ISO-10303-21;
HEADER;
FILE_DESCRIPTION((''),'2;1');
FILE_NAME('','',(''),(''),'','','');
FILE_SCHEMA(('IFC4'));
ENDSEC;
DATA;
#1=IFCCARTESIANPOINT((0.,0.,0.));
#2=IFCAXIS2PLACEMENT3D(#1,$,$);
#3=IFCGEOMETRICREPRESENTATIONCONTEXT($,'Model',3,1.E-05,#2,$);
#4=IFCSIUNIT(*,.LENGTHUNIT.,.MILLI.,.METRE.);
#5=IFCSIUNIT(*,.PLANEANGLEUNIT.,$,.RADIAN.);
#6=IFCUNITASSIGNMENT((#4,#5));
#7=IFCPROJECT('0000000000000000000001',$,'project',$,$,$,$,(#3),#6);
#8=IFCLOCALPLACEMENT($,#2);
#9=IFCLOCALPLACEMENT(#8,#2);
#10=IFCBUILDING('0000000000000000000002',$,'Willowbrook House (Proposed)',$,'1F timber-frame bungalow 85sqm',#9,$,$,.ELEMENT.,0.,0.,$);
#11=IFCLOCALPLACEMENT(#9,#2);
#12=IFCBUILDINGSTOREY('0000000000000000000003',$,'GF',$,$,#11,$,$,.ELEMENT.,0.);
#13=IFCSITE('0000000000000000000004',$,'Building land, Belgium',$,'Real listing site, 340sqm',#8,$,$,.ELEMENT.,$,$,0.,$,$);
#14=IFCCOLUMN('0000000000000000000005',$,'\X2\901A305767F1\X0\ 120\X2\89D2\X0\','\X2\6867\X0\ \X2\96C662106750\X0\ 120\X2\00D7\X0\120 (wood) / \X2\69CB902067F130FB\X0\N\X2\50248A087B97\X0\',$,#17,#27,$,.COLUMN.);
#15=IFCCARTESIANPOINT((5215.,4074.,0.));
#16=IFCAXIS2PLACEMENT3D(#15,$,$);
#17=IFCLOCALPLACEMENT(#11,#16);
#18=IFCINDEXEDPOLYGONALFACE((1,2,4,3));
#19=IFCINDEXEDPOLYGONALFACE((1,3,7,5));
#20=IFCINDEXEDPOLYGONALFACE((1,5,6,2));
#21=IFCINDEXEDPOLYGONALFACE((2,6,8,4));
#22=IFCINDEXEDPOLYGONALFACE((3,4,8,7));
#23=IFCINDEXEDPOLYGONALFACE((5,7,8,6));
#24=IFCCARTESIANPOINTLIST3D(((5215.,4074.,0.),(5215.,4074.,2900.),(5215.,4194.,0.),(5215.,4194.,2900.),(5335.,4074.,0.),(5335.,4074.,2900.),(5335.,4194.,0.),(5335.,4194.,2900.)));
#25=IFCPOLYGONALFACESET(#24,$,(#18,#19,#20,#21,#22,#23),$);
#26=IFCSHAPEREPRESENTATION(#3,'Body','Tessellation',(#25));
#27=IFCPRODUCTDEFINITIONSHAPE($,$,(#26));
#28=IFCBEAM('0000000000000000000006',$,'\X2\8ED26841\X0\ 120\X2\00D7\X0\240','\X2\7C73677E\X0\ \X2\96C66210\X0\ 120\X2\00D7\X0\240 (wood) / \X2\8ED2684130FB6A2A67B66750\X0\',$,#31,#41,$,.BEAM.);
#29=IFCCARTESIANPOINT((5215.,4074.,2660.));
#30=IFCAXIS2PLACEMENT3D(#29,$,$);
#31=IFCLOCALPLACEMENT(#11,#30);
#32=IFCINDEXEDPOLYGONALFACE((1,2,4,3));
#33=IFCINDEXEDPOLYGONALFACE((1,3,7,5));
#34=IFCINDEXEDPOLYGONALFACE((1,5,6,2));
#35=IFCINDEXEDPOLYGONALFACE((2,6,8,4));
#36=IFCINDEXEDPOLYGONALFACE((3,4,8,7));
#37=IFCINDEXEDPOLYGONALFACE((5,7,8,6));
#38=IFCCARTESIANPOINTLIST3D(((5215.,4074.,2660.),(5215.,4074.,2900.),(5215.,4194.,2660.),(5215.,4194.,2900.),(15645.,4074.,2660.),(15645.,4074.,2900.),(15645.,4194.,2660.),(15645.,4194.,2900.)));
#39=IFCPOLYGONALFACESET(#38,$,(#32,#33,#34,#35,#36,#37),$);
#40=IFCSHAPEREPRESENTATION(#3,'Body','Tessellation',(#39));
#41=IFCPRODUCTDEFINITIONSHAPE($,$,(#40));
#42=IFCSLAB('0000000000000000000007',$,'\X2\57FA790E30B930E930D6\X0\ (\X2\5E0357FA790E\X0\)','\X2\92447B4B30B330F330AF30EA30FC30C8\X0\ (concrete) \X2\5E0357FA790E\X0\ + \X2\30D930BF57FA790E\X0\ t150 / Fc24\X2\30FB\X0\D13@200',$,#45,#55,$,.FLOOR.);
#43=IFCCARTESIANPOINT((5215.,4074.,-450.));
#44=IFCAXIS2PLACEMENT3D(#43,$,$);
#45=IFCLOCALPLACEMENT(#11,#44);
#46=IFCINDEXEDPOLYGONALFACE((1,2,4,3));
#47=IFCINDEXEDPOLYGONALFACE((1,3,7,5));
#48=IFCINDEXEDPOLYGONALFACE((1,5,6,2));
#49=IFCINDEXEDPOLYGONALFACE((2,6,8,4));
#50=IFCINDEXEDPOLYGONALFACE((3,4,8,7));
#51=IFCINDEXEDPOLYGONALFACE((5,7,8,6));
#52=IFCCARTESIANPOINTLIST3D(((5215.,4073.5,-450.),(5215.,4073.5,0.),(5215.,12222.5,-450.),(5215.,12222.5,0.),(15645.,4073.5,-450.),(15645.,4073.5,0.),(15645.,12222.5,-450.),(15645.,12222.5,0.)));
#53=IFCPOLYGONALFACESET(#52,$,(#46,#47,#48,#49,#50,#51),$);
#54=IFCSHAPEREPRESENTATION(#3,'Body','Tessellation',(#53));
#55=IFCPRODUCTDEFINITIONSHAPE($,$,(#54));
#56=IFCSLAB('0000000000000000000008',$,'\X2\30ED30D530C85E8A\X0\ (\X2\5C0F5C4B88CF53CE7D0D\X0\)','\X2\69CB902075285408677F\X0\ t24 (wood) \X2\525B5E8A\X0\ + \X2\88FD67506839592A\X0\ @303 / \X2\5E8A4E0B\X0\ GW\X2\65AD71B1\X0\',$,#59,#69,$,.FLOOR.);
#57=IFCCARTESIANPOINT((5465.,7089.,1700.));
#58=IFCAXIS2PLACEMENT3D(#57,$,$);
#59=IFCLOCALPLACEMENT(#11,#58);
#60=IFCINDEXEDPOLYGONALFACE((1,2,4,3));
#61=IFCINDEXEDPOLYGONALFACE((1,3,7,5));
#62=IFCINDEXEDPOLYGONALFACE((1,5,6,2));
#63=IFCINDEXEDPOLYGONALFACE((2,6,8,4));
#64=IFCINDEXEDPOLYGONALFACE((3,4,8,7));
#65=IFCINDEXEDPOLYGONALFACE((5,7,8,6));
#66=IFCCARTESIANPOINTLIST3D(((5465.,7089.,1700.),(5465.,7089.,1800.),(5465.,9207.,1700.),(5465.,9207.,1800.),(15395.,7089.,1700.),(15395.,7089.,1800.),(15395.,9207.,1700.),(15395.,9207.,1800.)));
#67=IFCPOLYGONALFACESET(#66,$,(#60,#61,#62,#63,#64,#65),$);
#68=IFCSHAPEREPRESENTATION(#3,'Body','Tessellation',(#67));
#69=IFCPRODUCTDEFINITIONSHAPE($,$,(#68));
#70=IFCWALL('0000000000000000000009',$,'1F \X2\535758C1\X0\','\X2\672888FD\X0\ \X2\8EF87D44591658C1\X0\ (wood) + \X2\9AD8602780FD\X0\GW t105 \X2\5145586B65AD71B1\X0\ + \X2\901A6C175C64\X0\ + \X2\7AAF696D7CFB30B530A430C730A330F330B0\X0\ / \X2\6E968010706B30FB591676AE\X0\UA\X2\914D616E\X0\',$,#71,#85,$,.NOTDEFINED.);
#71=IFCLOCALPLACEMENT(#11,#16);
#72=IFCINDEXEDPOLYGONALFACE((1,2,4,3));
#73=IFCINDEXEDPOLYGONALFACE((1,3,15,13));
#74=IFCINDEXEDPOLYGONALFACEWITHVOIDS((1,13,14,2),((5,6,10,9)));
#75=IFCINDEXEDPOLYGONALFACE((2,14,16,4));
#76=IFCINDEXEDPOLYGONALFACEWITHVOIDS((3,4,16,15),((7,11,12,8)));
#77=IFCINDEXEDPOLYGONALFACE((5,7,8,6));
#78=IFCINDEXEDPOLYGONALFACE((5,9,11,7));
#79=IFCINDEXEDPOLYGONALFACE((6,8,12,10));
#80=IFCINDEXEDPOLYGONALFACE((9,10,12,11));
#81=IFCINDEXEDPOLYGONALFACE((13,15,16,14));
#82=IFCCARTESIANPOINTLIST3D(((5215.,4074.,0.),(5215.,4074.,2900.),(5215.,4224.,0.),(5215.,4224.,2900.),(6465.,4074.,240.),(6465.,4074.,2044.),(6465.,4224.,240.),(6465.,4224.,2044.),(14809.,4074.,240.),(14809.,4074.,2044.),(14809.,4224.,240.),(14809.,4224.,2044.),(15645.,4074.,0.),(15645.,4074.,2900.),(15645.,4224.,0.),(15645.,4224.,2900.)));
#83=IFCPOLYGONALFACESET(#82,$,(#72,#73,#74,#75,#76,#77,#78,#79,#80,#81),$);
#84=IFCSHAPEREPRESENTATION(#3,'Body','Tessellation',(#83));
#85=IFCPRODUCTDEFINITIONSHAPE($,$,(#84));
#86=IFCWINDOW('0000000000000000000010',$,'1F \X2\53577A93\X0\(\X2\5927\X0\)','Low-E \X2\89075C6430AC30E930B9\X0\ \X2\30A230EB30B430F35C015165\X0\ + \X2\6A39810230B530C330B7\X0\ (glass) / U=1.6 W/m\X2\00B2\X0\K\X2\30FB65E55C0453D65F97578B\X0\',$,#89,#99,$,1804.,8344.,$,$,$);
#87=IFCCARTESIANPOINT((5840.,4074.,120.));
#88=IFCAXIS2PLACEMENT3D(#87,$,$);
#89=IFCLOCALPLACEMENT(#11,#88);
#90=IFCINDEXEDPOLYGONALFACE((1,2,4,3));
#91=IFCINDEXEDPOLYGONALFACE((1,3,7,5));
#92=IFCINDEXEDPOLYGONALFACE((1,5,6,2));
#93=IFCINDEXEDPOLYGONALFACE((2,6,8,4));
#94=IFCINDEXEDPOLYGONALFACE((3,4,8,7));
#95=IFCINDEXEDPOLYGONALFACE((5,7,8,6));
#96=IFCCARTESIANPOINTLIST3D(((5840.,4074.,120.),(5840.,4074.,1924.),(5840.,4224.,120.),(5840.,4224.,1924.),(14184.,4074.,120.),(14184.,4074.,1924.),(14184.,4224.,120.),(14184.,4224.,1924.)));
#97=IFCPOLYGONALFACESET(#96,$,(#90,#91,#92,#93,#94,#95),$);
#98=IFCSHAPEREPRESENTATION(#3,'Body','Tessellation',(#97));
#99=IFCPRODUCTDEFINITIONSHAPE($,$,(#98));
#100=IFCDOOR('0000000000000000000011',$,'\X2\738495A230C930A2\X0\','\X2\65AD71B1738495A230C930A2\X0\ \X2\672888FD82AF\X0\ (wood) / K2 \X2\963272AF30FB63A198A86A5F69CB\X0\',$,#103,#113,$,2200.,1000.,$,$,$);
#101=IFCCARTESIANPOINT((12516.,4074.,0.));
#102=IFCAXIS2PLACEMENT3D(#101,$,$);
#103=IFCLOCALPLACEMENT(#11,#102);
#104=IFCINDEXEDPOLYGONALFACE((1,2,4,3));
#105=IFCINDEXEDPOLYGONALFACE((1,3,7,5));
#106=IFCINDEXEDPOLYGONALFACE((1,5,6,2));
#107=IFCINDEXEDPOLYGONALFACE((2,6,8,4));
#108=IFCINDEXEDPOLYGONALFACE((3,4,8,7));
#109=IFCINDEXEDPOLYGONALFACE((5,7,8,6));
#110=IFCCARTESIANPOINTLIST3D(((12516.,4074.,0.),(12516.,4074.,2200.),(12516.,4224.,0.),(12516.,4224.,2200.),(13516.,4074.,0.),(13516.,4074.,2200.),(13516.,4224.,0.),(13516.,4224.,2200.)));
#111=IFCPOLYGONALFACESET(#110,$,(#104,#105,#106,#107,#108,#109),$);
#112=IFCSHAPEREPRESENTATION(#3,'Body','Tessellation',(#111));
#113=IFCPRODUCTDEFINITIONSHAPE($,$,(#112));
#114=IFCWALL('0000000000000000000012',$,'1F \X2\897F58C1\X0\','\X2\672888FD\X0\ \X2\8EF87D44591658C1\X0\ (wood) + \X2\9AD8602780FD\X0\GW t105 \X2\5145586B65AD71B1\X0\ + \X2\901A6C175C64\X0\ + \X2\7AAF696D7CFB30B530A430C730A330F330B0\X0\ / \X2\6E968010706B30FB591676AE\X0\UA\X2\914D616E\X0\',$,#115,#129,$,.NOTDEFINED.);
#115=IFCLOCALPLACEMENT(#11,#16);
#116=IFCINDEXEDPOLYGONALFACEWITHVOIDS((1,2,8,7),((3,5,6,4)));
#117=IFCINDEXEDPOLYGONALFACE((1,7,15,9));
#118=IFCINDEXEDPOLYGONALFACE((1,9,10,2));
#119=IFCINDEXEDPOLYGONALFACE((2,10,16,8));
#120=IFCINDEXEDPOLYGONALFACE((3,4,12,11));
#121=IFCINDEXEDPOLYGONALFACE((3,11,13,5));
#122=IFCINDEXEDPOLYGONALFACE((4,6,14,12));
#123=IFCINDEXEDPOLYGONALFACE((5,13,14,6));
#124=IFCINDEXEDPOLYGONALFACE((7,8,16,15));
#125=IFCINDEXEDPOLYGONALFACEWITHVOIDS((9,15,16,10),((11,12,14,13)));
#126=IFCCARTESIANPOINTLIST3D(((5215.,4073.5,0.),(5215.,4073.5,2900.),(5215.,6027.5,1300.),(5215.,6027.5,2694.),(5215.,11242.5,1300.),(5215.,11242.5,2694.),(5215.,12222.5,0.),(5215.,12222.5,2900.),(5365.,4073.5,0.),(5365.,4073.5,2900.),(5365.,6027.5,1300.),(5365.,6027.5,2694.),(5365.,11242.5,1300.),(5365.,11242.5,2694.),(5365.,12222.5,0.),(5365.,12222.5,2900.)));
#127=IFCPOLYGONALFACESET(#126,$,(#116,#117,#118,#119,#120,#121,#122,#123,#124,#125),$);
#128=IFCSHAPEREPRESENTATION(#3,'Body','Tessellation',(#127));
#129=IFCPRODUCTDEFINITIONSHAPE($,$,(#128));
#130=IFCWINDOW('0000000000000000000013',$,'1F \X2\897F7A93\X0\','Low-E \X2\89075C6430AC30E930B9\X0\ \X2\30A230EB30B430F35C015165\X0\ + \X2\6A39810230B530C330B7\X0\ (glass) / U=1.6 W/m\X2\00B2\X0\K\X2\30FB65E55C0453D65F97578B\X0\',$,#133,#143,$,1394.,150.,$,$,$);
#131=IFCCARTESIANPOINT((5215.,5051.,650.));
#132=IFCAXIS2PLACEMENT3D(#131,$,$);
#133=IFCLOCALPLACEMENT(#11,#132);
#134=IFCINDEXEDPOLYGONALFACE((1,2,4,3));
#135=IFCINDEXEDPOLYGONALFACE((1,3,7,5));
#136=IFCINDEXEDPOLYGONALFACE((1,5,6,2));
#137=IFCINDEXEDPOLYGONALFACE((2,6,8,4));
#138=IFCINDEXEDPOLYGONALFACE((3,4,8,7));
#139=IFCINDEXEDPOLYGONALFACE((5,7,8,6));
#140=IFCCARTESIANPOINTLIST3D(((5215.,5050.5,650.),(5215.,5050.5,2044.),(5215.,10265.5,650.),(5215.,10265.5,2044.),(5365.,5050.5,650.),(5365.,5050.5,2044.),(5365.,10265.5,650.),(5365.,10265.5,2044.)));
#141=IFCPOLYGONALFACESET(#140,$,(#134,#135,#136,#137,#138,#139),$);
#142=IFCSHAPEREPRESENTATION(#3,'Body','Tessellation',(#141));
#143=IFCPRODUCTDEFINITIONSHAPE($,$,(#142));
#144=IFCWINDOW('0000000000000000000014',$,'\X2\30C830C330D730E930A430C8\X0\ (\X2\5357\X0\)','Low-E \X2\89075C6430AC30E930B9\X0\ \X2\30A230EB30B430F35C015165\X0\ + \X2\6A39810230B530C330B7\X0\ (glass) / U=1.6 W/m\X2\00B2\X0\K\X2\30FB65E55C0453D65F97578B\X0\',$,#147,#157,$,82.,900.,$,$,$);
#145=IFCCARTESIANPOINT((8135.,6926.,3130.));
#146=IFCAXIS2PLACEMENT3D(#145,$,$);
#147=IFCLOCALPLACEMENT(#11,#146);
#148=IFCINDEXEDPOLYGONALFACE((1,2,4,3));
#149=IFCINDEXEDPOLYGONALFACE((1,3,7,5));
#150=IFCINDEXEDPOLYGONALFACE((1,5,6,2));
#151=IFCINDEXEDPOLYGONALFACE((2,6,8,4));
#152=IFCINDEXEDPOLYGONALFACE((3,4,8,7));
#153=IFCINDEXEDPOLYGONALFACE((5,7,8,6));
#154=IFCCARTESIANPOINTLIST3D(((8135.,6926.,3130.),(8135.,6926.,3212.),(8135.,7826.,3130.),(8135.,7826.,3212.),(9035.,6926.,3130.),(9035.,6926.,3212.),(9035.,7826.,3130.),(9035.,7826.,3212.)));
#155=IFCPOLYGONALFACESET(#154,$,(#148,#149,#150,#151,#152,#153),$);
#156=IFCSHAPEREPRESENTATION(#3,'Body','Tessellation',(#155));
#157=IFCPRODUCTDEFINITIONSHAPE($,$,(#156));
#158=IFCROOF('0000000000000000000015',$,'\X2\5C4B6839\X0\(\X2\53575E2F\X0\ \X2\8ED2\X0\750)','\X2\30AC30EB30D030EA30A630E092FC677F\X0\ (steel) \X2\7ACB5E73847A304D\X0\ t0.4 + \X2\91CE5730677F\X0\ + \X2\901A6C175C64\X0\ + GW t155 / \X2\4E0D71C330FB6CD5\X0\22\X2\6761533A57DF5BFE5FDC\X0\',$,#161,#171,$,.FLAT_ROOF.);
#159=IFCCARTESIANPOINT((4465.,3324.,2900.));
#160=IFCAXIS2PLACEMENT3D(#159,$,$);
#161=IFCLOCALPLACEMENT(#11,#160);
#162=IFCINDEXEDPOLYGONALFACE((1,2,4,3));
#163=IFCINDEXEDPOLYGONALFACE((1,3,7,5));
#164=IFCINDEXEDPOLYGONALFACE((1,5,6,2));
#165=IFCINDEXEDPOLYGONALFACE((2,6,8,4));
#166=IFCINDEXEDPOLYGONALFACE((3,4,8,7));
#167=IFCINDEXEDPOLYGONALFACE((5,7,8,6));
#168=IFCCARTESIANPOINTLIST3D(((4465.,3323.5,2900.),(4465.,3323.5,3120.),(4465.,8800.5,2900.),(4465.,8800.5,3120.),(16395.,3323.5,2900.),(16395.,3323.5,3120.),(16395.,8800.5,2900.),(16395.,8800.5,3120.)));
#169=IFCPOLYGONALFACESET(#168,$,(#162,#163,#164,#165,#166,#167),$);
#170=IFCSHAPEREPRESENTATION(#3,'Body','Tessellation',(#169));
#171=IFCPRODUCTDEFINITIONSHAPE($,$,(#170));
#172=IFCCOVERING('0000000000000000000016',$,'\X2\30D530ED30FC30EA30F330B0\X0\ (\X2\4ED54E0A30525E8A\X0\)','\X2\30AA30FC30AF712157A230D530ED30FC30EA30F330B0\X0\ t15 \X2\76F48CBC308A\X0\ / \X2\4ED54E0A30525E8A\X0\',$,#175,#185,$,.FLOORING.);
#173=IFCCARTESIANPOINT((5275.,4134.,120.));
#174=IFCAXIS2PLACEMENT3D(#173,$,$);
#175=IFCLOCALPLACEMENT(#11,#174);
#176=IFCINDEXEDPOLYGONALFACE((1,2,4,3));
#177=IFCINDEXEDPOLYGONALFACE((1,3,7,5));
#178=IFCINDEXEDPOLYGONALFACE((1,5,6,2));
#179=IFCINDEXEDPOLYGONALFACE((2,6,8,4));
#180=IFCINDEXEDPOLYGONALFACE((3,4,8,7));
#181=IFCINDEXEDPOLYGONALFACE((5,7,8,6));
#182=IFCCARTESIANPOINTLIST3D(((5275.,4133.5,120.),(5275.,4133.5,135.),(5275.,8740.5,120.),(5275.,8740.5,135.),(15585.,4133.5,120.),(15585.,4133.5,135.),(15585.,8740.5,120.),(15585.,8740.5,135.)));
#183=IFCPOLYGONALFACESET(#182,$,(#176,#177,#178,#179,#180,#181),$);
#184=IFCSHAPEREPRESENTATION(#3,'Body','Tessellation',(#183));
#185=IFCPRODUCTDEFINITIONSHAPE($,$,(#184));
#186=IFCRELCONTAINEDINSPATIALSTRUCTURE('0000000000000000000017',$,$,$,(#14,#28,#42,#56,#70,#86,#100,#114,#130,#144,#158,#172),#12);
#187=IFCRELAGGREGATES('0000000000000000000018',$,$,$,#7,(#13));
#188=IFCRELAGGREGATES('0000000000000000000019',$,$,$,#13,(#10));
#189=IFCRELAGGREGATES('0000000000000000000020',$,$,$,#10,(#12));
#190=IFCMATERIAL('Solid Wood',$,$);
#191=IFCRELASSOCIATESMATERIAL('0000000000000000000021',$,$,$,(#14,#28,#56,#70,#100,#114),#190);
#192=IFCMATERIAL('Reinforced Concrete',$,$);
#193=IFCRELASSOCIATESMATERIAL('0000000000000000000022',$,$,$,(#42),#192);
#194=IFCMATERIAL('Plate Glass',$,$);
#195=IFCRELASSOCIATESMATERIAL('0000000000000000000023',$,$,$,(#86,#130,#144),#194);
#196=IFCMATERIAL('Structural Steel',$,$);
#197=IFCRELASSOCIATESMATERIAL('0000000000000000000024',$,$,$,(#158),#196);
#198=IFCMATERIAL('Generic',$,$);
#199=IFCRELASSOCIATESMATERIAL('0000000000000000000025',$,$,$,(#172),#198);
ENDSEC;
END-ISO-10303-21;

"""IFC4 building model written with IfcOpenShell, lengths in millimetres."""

from ifc_helpers import new_model, si_unit, frame, frame_2d, origin, place, context, project, spatial, rectangle, extrude, material, element, fill, save


model = new_model("IFC4")

# Units and contexts
model_context = context("Model", 3, precision=1e-05, world=origin())
ifc_project = project(units=[si_unit("LENGTHUNIT", "METRE", prefix="MILLI"), si_unit("PLANEANGLEUNIT", "RADIAN")], contexts=[model_context])

# Site, building, storey
site_placement = place(None, origin())
site = spatial("IfcSite", under=ifc_project, at=site_placement, Name="Building land, Belgium", ObjectType="Real listing site, 340sqm", CompositionType="ELEMENT", RefElevation=0.0)
building_placement = place(site_placement, origin())
building = spatial("IfcBuilding", under=site, at=building_placement, Name="Willowbrook House (Proposed)", ObjectType="1F timber-frame bungalow 85sqm", CompositionType="ELEMENT", ElevationOfRefHeight=0.0, ElevationOfTerrain=0.0)
storey_placement = place(building_placement, origin())
storey = spatial("IfcBuildingStorey", under=building, at=storey_placement, Name="GF", CompositionType="ELEMENT", Elevation=0.0)

# Column
ifc_material_1 = material(Name="Solid Wood")
column_1_placement = place(storey_placement, frame((5215.0, 4074.0, 0.0)))
element("IfcColumn", 1, at=column_1_placement, inside=storey, material=ifc_material_1, Name="通し柱 120角", Description="桧 集成材 120×120 (wood) / 構造柱・N値計算", PredefinedType="COLUMN", context=model_context, shape_type="SweptSolid", body=[
    extrude(rectangle(XDim=120.0, YDim=120.0, at=frame_2d((60.0, 60.0))), frame((5215.0, 4074.0, 0.0)), (0.0, 0.0, 1.0), 2900.0),
])

# Beam
beam_1_placement = place(storey_placement, frame((5215.0, 4074.0, 2660.0)))
element("IfcBeam", 2, at=beam_1_placement, inside=storey, material=ifc_material_1, Name="軒桁 120×240", Description="米松 集成 120×240 (wood) / 軒桁・横架材", PredefinedType="BEAM", context=model_context, shape_type="SweptSolid", body=[
    extrude(rectangle(XDim=10430.0, YDim=120.0, at=frame_2d((5215.0, 60.0))), frame((5215.0, 4074.0, 2660.0)), (0.0, 0.0, 1.0), 240.0),
])

# Slabs
ifc_material_2 = material(Name="Reinforced Concrete")
slab_1_placement = place(storey_placement, frame((5215.0, 4074.0, -450.0)))
element("IfcSlab", 3, at=slab_1_placement, inside=storey, material=ifc_material_2, Name="基礎スラブ (布基礎)", Description="鉄筋コンクリート (concrete) 布基礎 + ベタ基礎 t150 / Fc24・D13@200", PredefinedType="FLOOR", context=model_context, shape_type="SweptSolid", body=[
    extrude(rectangle(XDim=10430.0, YDim=8149.0, at=frame_2d((5215.0, 4074.0))), frame((5215.0, 4074.0, -450.0)), (0.0, 0.0, 1.0), 450.0),
])
slab_2_placement = place(storey_placement, frame((5465.0, 7089.0, 1700.0)))
element("IfcSlab", 4, at=slab_2_placement, inside=storey, material=ifc_material_1, Name="ロフト床 (小屋裏収納)", Description="構造用合板 t24 (wood) 剛床 + 製材根太 @303 / 床下 GW断熱", PredefinedType="FLOOR", context=model_context, shape_type="SweptSolid", body=[
    extrude(rectangle(XDim=9930.0, YDim=2118.0, at=frame_2d((4965.0, 1059.0))), frame((5465.0, 7089.0, 1700.0)), (0.0, 0.0, 1.0), 100.0),
])

# Wall, openings, window, door
wall_1_placement = place(storey_placement, frame((5215.0, 4074.0, 0.0)))
wall_1 = element("IfcWall", 5, at=wall_1_placement, inside=storey, material=ifc_material_1, Name="1F 南壁", Description="木製 軸組外壁 (wood) + 高性能GW t105 充填断熱 + 通気層 + 窯業系サイディング / 準耐火・外皮UA配慮", PredefinedType="NOTDEFINED", context=model_context, shape_type="SweptSolid", body=[
    extrude(rectangle(XDim=10430.0, YDim=150.0, at=frame_2d((5215.0, 75.0))), frame((5215.0, 4074.0, 0.0)), (0.0, 0.0, 1.0), 2900.0),
])
opening_1_placement = place(storey_placement, frame((5840.0, 4074.0, 120.0)))
opening_1 = element("IfcOpeningElement", 6, at=opening_1_placement, cuts=wall_1, PredefinedType="NOTDEFINED", context=model_context, shape_type="SweptSolid", body=[
    extrude(rectangle(XDim=8344.0, YDim=150.0, at=frame_2d((4172.0, 75.0))), frame((5840.0, 4074.0, 120.0)), (0.0, 0.0, 1.0), 1804.0),
])
opening_2_placement = place(storey_placement, frame((12516.0, 4074.0, 0.0)))
opening_2 = element("IfcOpeningElement", 7, at=opening_2_placement, cuts=wall_1, PredefinedType="NOTDEFINED", context=model_context, shape_type="SweptSolid", body=[
    extrude(rectangle(XDim=1000.0, YDim=150.0, at=frame_2d((500.0, 75.0))), frame((12516.0, 4074.0, 0.0)), (0.0, 0.0, 1.0), 2200.0),
])
ifc_material_3 = material(Name="Plate Glass")
window_1_placement = place(storey_placement, frame((5840.0, 4074.0, 120.0)))
window_1 = element("IfcWindow", 8, at=window_1_placement, inside=storey, material=ifc_material_3, Name="1F 南窓(大)", Description="Low-E 複層ガラス アルゴン封入 + 樹脂サッシ (glass) / U=1.6 W/m²K・日射取得型", OverallHeight=1804.0, OverallWidth=8344.0, context=model_context, shape_type="SweptSolid", body=[
    extrude(rectangle(XDim=8344.0, YDim=150.0, at=frame_2d((4172.0, 75.0))), frame((5840.0, 4074.0, 120.0)), (0.0, 0.0, 1.0), 1804.0),
])
fill(opening_1, window_1)
door_placement = place(storey_placement, frame((12516.0, 4074.0, 0.0)))
door = element("IfcDoor", 9, at=door_placement, inside=storey, material=ifc_material_1, Name="玄関ドア", Description="断熱玄関ドア 木製芯 (wood) / K2 防犯・採風機構", OverallHeight=2200.0, OverallWidth=1000.0, context=model_context, shape_type="SweptSolid", body=[
    extrude(rectangle(XDim=1000.0, YDim=150.0, at=frame_2d((500.0, 75.0))), frame((12516.0, 4074.0, 0.0)), (0.0, 0.0, 1.0), 2200.0),
])
fill(opening_2, door)

# Wall, opening, window
wall_2_placement = place(storey_placement, frame((5215.0, 4074.0, 0.0)))
wall_2 = element("IfcWall", 10, at=wall_2_placement, inside=storey, material=ifc_material_1, Name="1F 西壁", Description="木製 軸組外壁 (wood) + 高性能GW t105 充填断熱 + 通気層 + 窯業系サイディング / 準耐火・外皮UA配慮", PredefinedType="NOTDEFINED", context=model_context, shape_type="SweptSolid", body=[
    extrude(rectangle(XDim=150.0, YDim=8149.0, at=frame_2d((75.0, 4074.0))), frame((5215.0, 4074.0, 0.0)), (0.0, 0.0, 1.0), 2900.0),
])
opening_3_placement = place(storey_placement, frame((5215.0, 5051.0, 650.0)))
opening_3 = element("IfcOpeningElement", 11, at=opening_3_placement, cuts=wall_2, PredefinedType="NOTDEFINED", context=model_context, shape_type="SweptSolid", body=[
    extrude(rectangle(XDim=150.0, YDim=5215.0, at=frame_2d((75.0, 2607.0))), frame((5215.0, 5051.0, 650.0)), (0.0, 0.0, 1.0), 1394.0),
])
window_2_placement = place(storey_placement, frame((5215.0, 5051.0, 650.0)))
window_2 = element("IfcWindow", 12, at=window_2_placement, inside=storey, material=ifc_material_3, Name="1F 西窓", Description="Low-E 複層ガラス アルゴン封入 + 樹脂サッシ (glass) / U=1.6 W/m²K・日射取得型", OverallHeight=1394.0, OverallWidth=150.0, context=model_context, shape_type="SweptSolid", body=[
    extrude(rectangle(XDim=150.0, YDim=5215.0, at=frame_2d((75.0, 2607.0))), frame((5215.0, 5051.0, 650.0)), (0.0, 0.0, 1.0), 1394.0),
])
fill(opening_3, window_2)

# Window
window_3_placement = place(storey_placement, frame((8135.0, 6926.0, 3130.0)))
element("IfcWindow", 13, at=window_3_placement, inside=storey, material=ifc_material_3, Name="トップライト (南)", Description="Low-E 複層ガラス アルゴン封入 + 樹脂サッシ (glass) / U=1.6 W/m²K・日射取得型", OverallHeight=82.0, OverallWidth=900.0, context=model_context, shape_type="SweptSolid", body=[
    extrude(rectangle(XDim=900.0, YDim=900.0, at=frame_2d((450.0, 450.0))), frame((8135.0, 6926.0, 3130.0)), (0.0, 0.0, 1.0), 82.0),
])

# Roof
ifc_material_4 = material(Name="Structural Steel")
roof_placement = place(storey_placement, frame((4465.0, 3324.0, 2900.0)))
element("IfcRoof", 14, at=roof_placement, inside=storey, material=ifc_material_4, Name="屋根(南帯 軒750)", Description="ガルバリウム鋼板 (steel) 立平葺き t0.4 + 野地板 + 通気層 + GW t155 / 不燃・法22条区域対応", PredefinedType="FLAT_ROOF", context=model_context, shape_type="SweptSolid", body=[
    extrude(rectangle(XDim=11930.0, YDim=5477.0, at=frame_2d((5965.0, 2738.0))), frame((4465.0, 3324.0, 2900.0)), (0.0, 0.0, 1.0), 220.0),
])

# Covering
ifc_material_5 = material(Name="Generic")
covering_1_placement = place(storey_placement, frame((5275.0, 4134.0, 120.0)))
element("IfcCovering", 15, at=covering_1_placement, inside=storey, material=ifc_material_5, Name="フローリング (仕上げ床)", Description="オーク無垢フローリング t15 直貼り / 仕上げ床", PredefinedType="FLOORING", context=model_context, shape_type="SweptSolid", body=[
    extrude(rectangle(XDim=10310.0, YDim=4607.0, at=frame_2d((5155.0, 2303.0))), frame((5275.0, 4134.0, 120.0)), (0.0, 0.0, 1.0), 15.0),
])

save(model, "model.ifc")
